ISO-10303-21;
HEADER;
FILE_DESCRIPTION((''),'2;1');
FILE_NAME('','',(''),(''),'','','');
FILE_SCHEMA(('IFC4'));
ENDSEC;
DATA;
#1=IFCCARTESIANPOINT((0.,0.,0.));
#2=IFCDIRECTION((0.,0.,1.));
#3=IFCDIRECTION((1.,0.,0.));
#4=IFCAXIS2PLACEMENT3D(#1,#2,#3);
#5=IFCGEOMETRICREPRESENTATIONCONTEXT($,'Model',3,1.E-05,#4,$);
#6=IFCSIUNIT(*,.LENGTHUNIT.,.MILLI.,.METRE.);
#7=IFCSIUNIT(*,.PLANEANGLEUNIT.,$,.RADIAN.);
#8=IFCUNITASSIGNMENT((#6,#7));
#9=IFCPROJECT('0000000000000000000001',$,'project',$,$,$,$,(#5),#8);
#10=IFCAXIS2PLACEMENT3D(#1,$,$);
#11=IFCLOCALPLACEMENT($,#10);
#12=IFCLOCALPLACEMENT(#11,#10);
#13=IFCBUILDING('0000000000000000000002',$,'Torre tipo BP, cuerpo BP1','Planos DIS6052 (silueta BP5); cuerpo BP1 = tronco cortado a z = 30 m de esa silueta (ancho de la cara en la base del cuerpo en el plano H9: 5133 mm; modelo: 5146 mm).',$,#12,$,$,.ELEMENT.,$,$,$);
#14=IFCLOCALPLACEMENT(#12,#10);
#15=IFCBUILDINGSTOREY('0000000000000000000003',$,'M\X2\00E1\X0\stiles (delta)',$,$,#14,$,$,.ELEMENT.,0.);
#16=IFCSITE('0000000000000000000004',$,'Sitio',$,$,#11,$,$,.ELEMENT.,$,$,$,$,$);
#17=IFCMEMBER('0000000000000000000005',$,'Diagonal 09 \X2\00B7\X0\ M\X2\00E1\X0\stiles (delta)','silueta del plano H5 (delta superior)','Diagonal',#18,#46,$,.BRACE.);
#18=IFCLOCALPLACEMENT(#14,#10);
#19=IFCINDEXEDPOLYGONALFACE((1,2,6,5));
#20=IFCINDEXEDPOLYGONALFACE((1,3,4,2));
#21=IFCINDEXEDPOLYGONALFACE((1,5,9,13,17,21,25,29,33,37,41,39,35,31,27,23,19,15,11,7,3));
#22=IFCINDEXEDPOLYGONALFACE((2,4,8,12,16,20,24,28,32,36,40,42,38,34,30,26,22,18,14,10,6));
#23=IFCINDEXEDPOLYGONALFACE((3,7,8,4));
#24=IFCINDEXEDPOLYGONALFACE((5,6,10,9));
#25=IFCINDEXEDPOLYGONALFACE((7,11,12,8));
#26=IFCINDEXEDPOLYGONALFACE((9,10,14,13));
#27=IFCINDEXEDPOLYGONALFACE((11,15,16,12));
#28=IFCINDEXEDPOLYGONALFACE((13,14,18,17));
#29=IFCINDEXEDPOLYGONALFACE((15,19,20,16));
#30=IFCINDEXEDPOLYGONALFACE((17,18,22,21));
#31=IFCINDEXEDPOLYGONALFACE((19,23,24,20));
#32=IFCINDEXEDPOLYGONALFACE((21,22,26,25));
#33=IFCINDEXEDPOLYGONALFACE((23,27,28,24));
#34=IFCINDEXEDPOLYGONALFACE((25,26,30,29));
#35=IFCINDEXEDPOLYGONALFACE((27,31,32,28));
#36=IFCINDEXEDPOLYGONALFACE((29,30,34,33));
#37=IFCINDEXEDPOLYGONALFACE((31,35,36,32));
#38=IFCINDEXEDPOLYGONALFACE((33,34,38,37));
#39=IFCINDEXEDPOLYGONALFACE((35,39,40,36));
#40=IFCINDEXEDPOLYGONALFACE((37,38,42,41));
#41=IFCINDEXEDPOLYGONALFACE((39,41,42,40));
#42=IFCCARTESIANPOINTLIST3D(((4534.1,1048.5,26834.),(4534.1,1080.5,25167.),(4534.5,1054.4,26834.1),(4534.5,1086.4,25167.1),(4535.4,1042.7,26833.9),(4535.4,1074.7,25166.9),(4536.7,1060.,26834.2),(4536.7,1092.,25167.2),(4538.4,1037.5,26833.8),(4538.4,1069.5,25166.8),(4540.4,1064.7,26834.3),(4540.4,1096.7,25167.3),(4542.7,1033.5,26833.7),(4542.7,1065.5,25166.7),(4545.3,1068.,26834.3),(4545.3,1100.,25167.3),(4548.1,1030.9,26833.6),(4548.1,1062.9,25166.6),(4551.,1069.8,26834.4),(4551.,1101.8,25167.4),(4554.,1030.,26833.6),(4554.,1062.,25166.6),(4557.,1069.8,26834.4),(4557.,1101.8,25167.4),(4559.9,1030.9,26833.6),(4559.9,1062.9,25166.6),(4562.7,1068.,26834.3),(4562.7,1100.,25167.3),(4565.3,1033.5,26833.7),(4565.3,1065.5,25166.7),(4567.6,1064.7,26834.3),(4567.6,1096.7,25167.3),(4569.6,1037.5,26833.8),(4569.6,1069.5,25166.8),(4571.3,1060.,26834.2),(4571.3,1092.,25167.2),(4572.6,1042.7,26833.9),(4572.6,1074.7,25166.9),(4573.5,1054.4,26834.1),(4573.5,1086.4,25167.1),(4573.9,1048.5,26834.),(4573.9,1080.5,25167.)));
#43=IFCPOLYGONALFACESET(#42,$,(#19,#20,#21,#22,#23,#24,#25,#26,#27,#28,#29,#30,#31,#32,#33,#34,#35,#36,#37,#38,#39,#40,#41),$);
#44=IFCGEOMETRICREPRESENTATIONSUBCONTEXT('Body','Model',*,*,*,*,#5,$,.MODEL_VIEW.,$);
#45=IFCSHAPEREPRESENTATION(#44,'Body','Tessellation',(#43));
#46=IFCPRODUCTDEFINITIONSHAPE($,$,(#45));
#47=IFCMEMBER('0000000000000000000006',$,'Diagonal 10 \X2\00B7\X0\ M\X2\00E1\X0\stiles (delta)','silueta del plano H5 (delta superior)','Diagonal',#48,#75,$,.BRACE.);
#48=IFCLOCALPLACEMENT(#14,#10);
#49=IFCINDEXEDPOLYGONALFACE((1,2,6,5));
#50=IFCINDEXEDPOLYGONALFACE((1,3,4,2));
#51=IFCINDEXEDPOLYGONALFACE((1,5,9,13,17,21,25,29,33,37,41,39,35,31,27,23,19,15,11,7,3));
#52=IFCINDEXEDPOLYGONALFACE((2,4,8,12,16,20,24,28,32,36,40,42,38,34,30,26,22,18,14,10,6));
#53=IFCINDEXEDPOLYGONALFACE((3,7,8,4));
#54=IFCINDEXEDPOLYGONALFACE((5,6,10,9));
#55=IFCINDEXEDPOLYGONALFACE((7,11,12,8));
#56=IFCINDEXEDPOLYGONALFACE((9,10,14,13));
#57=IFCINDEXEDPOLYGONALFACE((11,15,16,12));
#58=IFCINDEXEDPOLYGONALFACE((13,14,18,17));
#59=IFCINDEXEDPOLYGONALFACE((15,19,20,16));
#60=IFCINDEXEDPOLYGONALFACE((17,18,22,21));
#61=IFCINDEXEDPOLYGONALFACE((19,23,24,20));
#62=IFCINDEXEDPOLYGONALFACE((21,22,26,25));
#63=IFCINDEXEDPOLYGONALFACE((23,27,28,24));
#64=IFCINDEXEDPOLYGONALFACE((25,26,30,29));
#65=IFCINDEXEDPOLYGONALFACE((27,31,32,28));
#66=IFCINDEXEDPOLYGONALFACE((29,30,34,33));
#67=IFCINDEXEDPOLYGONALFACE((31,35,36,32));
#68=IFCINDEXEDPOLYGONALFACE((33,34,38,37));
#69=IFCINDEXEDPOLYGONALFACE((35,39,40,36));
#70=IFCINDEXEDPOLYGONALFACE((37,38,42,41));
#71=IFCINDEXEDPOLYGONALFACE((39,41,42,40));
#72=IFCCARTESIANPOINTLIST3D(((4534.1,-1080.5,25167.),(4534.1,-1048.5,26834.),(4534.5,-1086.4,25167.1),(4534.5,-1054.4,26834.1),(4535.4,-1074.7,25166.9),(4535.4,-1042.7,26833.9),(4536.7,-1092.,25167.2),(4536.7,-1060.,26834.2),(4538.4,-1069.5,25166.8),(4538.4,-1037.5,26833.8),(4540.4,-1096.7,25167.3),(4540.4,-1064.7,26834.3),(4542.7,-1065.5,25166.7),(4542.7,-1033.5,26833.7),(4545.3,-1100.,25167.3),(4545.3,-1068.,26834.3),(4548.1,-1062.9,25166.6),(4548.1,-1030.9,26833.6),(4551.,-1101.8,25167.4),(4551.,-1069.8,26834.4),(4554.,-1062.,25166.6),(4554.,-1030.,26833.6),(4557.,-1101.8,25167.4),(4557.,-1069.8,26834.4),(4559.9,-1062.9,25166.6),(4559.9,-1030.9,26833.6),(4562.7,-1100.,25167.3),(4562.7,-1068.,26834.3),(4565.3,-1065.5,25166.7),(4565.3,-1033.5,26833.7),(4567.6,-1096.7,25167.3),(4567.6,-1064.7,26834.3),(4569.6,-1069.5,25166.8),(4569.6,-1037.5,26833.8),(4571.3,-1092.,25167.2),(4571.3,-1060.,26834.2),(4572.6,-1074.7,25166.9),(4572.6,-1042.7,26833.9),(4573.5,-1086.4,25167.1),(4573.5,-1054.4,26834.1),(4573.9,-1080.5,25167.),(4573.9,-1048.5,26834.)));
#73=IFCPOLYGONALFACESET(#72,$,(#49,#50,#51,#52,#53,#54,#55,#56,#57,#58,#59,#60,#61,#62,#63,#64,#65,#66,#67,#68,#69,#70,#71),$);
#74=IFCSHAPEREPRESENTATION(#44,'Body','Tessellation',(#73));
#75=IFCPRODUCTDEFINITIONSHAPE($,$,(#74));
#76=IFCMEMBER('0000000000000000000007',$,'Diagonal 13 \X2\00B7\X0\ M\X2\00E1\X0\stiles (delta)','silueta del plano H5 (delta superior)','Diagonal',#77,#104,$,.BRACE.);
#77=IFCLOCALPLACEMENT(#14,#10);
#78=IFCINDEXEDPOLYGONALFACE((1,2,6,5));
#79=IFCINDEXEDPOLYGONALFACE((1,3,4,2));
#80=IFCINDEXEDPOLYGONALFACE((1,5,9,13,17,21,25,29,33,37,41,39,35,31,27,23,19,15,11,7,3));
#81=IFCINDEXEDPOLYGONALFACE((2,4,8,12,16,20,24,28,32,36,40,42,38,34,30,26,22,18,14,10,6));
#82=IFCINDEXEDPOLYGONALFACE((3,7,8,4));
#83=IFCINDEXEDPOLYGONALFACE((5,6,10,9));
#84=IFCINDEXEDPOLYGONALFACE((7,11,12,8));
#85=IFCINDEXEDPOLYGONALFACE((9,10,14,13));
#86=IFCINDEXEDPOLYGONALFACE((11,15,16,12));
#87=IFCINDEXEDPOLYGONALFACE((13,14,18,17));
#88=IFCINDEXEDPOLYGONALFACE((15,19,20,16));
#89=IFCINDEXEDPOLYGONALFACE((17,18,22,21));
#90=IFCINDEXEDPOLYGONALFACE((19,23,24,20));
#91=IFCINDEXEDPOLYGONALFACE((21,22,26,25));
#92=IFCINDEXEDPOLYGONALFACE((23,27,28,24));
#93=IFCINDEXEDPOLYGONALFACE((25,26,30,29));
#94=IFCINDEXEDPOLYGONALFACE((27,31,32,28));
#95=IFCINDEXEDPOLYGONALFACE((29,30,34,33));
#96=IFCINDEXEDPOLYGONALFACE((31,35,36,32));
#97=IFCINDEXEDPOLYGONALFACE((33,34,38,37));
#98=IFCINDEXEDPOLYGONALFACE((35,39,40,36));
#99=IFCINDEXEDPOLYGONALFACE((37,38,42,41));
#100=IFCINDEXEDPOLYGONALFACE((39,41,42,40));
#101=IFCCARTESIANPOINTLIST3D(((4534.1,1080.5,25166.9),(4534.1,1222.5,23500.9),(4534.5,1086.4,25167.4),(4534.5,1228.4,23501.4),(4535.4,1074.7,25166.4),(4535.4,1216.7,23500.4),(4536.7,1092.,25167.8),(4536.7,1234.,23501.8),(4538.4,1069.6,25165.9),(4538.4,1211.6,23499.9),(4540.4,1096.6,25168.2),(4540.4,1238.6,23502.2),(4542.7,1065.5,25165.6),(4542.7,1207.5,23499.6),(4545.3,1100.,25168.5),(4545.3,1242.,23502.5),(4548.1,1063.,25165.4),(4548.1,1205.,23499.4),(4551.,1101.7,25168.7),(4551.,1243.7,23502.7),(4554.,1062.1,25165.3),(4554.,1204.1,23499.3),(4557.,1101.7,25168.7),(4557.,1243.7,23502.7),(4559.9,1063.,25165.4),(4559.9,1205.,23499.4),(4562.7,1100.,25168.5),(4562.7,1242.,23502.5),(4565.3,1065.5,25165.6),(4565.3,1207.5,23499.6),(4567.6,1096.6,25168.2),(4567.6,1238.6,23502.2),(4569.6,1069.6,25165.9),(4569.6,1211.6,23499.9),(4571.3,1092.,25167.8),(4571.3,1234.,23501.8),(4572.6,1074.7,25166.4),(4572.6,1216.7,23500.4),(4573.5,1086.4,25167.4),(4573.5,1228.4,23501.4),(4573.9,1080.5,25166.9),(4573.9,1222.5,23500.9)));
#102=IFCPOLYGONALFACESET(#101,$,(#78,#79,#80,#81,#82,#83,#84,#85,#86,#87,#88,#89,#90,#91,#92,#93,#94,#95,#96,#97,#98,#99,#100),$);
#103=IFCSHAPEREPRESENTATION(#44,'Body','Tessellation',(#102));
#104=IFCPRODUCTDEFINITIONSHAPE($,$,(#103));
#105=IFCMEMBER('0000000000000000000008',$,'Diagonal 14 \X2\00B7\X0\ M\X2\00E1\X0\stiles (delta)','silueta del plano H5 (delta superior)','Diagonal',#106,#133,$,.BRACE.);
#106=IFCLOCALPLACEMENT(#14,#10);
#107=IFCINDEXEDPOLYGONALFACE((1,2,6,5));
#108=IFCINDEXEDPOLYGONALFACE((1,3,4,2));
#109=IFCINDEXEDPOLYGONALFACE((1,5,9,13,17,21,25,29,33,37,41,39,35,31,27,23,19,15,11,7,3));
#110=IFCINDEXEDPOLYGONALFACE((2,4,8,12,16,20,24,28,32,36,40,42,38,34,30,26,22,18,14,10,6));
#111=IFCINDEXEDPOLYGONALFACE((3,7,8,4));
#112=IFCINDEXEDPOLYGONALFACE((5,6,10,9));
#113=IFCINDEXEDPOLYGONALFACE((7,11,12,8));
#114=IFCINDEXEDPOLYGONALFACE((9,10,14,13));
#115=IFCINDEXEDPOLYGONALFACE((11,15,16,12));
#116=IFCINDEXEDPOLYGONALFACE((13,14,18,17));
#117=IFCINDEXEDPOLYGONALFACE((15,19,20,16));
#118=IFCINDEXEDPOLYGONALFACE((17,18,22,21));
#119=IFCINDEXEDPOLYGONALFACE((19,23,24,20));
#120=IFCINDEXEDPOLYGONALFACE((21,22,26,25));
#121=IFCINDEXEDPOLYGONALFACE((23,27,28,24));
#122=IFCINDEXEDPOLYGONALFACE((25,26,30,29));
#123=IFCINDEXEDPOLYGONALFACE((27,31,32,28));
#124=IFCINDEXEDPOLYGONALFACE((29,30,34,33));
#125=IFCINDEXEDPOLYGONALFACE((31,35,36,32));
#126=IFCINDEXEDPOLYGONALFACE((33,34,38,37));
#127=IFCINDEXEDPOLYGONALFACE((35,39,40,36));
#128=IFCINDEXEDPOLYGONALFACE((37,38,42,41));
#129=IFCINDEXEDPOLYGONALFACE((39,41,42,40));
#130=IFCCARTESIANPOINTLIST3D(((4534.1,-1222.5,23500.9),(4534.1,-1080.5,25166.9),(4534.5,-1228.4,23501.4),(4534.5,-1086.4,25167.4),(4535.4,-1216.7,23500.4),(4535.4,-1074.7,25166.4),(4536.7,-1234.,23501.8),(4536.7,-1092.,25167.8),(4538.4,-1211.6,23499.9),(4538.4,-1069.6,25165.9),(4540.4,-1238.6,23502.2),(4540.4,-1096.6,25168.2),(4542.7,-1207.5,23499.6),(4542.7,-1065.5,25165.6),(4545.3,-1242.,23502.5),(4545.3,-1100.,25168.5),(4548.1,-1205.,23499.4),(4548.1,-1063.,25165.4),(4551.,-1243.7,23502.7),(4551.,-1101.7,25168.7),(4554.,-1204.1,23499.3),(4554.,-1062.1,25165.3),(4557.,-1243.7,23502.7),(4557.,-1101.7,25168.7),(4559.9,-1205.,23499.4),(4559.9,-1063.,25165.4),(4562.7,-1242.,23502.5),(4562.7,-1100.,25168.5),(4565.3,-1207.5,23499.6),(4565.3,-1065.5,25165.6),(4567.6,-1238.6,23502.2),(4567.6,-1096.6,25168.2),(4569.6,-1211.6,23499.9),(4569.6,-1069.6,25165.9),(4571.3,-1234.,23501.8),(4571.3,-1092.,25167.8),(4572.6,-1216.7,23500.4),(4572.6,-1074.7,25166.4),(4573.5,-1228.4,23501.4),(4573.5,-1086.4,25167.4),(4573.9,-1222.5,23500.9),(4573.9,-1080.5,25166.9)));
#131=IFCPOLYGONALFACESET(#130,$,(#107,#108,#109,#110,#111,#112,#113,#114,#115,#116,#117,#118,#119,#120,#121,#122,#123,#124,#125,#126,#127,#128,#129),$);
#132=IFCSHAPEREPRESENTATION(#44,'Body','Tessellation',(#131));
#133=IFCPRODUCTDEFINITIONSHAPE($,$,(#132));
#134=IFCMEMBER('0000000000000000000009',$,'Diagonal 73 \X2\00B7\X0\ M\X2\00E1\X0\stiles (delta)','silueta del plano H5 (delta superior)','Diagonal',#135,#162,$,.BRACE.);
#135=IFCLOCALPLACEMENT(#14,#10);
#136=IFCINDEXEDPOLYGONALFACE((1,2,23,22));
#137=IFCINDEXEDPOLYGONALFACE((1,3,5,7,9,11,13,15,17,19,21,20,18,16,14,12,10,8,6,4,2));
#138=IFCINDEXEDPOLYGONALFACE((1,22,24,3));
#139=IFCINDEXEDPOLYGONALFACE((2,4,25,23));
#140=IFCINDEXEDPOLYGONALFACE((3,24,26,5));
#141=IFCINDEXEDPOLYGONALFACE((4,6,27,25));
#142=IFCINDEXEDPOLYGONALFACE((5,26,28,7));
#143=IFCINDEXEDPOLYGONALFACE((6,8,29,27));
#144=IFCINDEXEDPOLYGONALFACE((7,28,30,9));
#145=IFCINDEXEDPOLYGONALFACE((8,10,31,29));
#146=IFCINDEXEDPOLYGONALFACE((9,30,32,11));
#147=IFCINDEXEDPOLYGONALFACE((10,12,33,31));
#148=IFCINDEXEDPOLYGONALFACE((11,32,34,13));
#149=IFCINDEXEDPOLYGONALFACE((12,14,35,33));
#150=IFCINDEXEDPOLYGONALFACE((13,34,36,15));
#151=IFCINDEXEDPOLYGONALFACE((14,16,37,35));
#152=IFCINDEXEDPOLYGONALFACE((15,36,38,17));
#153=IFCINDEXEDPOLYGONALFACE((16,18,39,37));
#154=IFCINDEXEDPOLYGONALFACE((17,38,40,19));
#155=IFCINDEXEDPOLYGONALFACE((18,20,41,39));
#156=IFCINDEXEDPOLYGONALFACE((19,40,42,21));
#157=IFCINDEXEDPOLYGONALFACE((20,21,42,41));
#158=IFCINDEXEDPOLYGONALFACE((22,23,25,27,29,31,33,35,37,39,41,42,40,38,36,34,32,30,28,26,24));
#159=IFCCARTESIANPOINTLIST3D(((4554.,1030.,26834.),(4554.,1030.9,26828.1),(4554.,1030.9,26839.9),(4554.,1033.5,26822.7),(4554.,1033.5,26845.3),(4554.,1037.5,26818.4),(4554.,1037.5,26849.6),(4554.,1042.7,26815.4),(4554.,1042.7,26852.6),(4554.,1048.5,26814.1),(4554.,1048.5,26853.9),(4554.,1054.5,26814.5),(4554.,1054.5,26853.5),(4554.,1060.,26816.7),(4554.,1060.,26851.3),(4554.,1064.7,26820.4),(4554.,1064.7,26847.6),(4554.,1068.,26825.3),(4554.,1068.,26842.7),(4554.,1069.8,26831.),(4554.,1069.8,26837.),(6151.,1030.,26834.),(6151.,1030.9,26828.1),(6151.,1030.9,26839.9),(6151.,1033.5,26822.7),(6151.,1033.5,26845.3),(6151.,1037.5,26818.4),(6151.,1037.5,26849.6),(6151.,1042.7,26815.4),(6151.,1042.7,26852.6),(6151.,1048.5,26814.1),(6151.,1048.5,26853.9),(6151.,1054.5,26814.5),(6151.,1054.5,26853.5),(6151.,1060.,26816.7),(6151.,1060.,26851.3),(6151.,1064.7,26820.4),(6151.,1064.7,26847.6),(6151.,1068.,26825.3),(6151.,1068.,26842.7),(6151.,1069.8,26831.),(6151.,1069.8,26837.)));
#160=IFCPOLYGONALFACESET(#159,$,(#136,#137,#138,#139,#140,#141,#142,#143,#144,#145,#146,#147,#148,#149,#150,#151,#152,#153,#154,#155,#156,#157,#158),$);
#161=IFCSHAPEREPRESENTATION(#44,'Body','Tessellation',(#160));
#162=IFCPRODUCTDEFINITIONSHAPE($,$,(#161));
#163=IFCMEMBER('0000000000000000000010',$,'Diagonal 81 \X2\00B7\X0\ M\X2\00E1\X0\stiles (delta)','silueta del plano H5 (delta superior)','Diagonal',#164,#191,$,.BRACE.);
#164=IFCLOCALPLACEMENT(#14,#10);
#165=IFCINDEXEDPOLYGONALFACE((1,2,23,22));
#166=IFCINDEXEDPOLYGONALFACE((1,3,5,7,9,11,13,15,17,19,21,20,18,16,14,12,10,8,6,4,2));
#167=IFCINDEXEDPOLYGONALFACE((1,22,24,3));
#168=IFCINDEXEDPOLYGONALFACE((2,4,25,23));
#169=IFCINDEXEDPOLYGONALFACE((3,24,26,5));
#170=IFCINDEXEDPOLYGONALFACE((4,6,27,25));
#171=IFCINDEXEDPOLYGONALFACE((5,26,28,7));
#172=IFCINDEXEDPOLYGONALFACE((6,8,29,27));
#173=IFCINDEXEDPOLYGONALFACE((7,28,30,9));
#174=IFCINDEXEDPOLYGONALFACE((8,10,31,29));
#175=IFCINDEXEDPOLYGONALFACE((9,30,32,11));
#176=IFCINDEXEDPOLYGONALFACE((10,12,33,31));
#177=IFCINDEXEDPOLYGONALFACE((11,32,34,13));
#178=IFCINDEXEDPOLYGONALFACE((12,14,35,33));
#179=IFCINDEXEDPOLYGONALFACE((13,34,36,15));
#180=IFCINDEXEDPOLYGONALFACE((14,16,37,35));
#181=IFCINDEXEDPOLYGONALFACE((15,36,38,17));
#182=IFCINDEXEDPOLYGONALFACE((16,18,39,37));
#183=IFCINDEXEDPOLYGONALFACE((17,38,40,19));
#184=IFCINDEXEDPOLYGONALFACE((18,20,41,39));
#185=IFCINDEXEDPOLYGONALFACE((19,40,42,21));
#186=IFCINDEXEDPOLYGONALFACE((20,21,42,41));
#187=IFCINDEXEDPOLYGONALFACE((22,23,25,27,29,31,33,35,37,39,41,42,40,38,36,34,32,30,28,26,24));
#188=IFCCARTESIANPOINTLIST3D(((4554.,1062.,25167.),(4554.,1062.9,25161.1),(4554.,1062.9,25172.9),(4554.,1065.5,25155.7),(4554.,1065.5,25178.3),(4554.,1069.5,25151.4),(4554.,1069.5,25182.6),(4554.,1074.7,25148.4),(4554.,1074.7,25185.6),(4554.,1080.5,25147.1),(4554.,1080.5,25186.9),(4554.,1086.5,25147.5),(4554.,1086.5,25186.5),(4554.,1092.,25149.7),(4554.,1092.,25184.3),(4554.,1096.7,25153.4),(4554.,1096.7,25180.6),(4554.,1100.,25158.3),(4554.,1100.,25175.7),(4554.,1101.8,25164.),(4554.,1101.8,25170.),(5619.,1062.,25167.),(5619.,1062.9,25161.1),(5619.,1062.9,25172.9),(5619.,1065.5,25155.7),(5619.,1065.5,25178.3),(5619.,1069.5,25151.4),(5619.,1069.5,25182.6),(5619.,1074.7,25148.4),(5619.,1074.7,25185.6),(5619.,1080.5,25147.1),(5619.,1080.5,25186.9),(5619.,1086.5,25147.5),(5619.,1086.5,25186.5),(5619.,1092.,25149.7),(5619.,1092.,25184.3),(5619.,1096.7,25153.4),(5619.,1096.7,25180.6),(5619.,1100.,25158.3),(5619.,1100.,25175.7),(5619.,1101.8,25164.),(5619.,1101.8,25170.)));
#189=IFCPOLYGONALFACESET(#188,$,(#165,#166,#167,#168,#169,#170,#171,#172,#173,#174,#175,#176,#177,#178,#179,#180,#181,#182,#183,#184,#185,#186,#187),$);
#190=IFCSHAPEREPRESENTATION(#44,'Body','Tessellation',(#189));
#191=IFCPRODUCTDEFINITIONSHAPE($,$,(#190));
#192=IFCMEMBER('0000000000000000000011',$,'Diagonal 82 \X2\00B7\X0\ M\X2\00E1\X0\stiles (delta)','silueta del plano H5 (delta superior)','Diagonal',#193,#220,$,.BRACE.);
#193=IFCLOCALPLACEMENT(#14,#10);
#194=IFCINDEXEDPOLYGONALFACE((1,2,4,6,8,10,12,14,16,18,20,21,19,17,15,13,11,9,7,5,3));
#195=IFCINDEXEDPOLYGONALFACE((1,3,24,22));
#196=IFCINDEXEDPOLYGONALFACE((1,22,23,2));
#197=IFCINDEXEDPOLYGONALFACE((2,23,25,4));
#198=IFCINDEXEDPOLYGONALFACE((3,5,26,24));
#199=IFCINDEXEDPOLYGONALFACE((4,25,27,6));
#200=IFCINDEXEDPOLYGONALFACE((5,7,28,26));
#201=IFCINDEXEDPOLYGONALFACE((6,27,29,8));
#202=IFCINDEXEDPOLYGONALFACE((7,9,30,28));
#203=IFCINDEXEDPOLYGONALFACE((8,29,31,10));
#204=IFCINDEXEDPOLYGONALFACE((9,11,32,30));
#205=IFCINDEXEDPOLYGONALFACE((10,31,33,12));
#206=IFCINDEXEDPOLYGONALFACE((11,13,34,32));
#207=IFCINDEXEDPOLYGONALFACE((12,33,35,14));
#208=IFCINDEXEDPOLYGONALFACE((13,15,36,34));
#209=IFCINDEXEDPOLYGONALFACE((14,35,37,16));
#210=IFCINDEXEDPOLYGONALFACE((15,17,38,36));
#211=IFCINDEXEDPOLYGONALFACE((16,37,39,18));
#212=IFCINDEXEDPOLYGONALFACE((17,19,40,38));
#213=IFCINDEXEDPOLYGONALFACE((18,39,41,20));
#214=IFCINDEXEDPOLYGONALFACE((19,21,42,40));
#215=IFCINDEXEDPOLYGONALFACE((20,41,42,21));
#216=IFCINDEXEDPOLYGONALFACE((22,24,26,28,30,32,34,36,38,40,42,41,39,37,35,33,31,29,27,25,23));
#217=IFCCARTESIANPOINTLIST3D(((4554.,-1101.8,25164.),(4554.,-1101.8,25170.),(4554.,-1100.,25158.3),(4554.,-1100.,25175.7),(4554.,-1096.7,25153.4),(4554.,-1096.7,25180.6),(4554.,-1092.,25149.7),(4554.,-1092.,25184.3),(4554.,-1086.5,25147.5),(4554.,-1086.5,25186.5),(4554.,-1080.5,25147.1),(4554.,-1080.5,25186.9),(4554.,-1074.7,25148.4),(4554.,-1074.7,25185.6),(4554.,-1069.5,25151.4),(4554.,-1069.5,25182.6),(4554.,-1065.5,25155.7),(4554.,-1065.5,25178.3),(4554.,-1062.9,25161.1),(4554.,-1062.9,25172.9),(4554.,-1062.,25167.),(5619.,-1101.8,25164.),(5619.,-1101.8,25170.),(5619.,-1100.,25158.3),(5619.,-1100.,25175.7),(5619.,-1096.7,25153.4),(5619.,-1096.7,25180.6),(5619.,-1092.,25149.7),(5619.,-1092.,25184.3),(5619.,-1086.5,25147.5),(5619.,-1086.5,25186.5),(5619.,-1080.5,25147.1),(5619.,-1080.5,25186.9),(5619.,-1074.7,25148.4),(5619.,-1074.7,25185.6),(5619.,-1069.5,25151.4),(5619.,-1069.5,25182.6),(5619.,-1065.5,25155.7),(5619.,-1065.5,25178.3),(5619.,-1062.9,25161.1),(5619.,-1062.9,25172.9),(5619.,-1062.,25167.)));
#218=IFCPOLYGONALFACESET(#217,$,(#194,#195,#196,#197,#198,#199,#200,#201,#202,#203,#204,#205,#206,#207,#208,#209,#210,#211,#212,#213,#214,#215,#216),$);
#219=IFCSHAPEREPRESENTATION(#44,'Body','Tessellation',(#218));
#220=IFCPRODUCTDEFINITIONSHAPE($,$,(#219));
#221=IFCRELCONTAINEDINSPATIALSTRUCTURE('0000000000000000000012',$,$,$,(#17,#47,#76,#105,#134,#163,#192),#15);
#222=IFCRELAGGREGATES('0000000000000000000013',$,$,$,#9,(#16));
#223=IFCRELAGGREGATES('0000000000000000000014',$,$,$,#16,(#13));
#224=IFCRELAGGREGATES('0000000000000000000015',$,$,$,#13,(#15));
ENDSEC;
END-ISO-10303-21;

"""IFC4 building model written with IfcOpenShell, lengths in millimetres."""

from ifc_helpers import new_model, si_unit, frame, origin, origin_with_axes, place, context, subcontext, project, spatial, circle, extrude, element, save


model = new_model("IFC4")

# Units and contexts
model_context = context("Model", 3, precision=1e-05, world=origin_with_axes())
body_context = subcontext(model_context, "Body", "Model", "MODEL_VIEW")
ifc_project = project(units=[si_unit("LENGTHUNIT", "METRE", prefix="MILLI"), si_unit("PLANEANGLEUNIT", "RADIAN")], contexts=[model_context])

# Site, building, storey
site_placement = place(None, origin())
site = spatial("IfcSite", under=ifc_project, at=site_placement, Name="Sitio", CompositionType="ELEMENT")
building_placement = place(site_placement, origin())
building = spatial("IfcBuilding", under=site, at=building_placement, Name="Torre tipo BP, cuerpo BP1", Description="Planos DIS6052 (silueta BP5); cuerpo BP1 = tronco cortado a z = 30 m de esa silueta (ancho de la cara en la base del cuerpo en el plano H9: 5133 mm; modelo: 5146 mm).", CompositionType="ELEMENT")
storey_placement = place(building_placement, origin())
storey = spatial("IfcBuildingStorey", under=building, at=storey_placement, Name="Mástiles (delta)", CompositionType="ELEMENT", Elevation=0.0)

# Members
for number, where, z_axis, x_axis, name in (
    (1, (4554.0, 1050.0, 26834.0), (0.0, 0.019193, -0.999816), (0.0, -0.999816, -0.019193), "Diagonal 09 · Mástiles (delta)"),
    (2, (4554.0, -1050.0, 26834.0), (0.0, -0.019193, -0.999816), (0.0, 0.999816, -0.019193), "Diagonal 10 · Mástiles (delta)"),
):
    element("IfcMember", number, at=place(storey_placement, frame(where, z_axis=z_axis, x_axis=x_axis)), inside=storey, Name=name, Description="silueta del plano H5 (delta superior)", ObjectType="Diagonal", PredefinedType="BRACE", context=body_context, shape_type="SweptSolid", body=[
        extrude(circle(Radius=20.0), None, (0.0, 0.0, 1.0), 1667.3),
    ])
for number, where, z_axis, x_axis, name in (
    (3, (4554.0, 1082.0, 25167.0), (0.0, 0.084926, -0.996387), (0.0, -0.996387, -0.084926), "Diagonal 13 · Mástiles (delta)"),
    (4, (4554.0, -1082.0, 25167.0), (0.0, -0.084926, -0.996387), (0.0, 0.996387, -0.084926), "Diagonal 14 · Mástiles (delta)"),
):
    element("IfcMember", number, at=place(storey_placement, frame(where, z_axis=z_axis, x_axis=x_axis)), inside=storey, Name=name, Description="silueta del plano H5 (delta superior)", ObjectType="Diagonal", PredefinedType="BRACE", context=body_context, shape_type="SweptSolid", body=[
        extrude(circle(Radius=20.0), None, (0.0, 0.0, 1.0), 1672.0),
    ])
member_1_placement = place(storey_placement, frame((4554.0, 1050.0, 26834.0), z_axis=(1.0, 0.0, 0.0), x_axis=(0.0, -1.0, 0.0)))
element("IfcMember", 5, at=member_1_placement, inside=storey, Name="Diagonal 73 · Mástiles (delta)", Description="silueta del plano H5 (delta superior)", ObjectType="Diagonal", PredefinedType="BRACE", context=body_context, shape_type="SweptSolid", body=[
    extrude(circle(Radius=20.0), None, (0.0, 0.0, 1.0), 1597.0),
])
for number, where, z_axis, x_axis, name in (
    (6, (4554.0, 1082.0, 25167.0), (1.0, 0.0, 0.0), (0.0, -1.0, 0.0), "Diagonal 81 · Mástiles (delta)"),
    (7, (4554.0, -1082.0, 25167.0), (1.0, 0.0, 0.0), (0.0, 1.0, 0.0), "Diagonal 82 · Mástiles (delta)"),
):
    element("IfcMember", number, at=place(storey_placement, frame(where, z_axis=z_axis, x_axis=x_axis)), inside=storey, Name=name, Description="silueta del plano H5 (delta superior)", ObjectType="Diagonal", PredefinedType="BRACE", context=body_context, shape_type="SweptSolid", body=[
        extrude(circle(Radius=20.0), None, (0.0, 0.0, 1.0), 1065.0),
    ])

save(model, "model.ifc")
